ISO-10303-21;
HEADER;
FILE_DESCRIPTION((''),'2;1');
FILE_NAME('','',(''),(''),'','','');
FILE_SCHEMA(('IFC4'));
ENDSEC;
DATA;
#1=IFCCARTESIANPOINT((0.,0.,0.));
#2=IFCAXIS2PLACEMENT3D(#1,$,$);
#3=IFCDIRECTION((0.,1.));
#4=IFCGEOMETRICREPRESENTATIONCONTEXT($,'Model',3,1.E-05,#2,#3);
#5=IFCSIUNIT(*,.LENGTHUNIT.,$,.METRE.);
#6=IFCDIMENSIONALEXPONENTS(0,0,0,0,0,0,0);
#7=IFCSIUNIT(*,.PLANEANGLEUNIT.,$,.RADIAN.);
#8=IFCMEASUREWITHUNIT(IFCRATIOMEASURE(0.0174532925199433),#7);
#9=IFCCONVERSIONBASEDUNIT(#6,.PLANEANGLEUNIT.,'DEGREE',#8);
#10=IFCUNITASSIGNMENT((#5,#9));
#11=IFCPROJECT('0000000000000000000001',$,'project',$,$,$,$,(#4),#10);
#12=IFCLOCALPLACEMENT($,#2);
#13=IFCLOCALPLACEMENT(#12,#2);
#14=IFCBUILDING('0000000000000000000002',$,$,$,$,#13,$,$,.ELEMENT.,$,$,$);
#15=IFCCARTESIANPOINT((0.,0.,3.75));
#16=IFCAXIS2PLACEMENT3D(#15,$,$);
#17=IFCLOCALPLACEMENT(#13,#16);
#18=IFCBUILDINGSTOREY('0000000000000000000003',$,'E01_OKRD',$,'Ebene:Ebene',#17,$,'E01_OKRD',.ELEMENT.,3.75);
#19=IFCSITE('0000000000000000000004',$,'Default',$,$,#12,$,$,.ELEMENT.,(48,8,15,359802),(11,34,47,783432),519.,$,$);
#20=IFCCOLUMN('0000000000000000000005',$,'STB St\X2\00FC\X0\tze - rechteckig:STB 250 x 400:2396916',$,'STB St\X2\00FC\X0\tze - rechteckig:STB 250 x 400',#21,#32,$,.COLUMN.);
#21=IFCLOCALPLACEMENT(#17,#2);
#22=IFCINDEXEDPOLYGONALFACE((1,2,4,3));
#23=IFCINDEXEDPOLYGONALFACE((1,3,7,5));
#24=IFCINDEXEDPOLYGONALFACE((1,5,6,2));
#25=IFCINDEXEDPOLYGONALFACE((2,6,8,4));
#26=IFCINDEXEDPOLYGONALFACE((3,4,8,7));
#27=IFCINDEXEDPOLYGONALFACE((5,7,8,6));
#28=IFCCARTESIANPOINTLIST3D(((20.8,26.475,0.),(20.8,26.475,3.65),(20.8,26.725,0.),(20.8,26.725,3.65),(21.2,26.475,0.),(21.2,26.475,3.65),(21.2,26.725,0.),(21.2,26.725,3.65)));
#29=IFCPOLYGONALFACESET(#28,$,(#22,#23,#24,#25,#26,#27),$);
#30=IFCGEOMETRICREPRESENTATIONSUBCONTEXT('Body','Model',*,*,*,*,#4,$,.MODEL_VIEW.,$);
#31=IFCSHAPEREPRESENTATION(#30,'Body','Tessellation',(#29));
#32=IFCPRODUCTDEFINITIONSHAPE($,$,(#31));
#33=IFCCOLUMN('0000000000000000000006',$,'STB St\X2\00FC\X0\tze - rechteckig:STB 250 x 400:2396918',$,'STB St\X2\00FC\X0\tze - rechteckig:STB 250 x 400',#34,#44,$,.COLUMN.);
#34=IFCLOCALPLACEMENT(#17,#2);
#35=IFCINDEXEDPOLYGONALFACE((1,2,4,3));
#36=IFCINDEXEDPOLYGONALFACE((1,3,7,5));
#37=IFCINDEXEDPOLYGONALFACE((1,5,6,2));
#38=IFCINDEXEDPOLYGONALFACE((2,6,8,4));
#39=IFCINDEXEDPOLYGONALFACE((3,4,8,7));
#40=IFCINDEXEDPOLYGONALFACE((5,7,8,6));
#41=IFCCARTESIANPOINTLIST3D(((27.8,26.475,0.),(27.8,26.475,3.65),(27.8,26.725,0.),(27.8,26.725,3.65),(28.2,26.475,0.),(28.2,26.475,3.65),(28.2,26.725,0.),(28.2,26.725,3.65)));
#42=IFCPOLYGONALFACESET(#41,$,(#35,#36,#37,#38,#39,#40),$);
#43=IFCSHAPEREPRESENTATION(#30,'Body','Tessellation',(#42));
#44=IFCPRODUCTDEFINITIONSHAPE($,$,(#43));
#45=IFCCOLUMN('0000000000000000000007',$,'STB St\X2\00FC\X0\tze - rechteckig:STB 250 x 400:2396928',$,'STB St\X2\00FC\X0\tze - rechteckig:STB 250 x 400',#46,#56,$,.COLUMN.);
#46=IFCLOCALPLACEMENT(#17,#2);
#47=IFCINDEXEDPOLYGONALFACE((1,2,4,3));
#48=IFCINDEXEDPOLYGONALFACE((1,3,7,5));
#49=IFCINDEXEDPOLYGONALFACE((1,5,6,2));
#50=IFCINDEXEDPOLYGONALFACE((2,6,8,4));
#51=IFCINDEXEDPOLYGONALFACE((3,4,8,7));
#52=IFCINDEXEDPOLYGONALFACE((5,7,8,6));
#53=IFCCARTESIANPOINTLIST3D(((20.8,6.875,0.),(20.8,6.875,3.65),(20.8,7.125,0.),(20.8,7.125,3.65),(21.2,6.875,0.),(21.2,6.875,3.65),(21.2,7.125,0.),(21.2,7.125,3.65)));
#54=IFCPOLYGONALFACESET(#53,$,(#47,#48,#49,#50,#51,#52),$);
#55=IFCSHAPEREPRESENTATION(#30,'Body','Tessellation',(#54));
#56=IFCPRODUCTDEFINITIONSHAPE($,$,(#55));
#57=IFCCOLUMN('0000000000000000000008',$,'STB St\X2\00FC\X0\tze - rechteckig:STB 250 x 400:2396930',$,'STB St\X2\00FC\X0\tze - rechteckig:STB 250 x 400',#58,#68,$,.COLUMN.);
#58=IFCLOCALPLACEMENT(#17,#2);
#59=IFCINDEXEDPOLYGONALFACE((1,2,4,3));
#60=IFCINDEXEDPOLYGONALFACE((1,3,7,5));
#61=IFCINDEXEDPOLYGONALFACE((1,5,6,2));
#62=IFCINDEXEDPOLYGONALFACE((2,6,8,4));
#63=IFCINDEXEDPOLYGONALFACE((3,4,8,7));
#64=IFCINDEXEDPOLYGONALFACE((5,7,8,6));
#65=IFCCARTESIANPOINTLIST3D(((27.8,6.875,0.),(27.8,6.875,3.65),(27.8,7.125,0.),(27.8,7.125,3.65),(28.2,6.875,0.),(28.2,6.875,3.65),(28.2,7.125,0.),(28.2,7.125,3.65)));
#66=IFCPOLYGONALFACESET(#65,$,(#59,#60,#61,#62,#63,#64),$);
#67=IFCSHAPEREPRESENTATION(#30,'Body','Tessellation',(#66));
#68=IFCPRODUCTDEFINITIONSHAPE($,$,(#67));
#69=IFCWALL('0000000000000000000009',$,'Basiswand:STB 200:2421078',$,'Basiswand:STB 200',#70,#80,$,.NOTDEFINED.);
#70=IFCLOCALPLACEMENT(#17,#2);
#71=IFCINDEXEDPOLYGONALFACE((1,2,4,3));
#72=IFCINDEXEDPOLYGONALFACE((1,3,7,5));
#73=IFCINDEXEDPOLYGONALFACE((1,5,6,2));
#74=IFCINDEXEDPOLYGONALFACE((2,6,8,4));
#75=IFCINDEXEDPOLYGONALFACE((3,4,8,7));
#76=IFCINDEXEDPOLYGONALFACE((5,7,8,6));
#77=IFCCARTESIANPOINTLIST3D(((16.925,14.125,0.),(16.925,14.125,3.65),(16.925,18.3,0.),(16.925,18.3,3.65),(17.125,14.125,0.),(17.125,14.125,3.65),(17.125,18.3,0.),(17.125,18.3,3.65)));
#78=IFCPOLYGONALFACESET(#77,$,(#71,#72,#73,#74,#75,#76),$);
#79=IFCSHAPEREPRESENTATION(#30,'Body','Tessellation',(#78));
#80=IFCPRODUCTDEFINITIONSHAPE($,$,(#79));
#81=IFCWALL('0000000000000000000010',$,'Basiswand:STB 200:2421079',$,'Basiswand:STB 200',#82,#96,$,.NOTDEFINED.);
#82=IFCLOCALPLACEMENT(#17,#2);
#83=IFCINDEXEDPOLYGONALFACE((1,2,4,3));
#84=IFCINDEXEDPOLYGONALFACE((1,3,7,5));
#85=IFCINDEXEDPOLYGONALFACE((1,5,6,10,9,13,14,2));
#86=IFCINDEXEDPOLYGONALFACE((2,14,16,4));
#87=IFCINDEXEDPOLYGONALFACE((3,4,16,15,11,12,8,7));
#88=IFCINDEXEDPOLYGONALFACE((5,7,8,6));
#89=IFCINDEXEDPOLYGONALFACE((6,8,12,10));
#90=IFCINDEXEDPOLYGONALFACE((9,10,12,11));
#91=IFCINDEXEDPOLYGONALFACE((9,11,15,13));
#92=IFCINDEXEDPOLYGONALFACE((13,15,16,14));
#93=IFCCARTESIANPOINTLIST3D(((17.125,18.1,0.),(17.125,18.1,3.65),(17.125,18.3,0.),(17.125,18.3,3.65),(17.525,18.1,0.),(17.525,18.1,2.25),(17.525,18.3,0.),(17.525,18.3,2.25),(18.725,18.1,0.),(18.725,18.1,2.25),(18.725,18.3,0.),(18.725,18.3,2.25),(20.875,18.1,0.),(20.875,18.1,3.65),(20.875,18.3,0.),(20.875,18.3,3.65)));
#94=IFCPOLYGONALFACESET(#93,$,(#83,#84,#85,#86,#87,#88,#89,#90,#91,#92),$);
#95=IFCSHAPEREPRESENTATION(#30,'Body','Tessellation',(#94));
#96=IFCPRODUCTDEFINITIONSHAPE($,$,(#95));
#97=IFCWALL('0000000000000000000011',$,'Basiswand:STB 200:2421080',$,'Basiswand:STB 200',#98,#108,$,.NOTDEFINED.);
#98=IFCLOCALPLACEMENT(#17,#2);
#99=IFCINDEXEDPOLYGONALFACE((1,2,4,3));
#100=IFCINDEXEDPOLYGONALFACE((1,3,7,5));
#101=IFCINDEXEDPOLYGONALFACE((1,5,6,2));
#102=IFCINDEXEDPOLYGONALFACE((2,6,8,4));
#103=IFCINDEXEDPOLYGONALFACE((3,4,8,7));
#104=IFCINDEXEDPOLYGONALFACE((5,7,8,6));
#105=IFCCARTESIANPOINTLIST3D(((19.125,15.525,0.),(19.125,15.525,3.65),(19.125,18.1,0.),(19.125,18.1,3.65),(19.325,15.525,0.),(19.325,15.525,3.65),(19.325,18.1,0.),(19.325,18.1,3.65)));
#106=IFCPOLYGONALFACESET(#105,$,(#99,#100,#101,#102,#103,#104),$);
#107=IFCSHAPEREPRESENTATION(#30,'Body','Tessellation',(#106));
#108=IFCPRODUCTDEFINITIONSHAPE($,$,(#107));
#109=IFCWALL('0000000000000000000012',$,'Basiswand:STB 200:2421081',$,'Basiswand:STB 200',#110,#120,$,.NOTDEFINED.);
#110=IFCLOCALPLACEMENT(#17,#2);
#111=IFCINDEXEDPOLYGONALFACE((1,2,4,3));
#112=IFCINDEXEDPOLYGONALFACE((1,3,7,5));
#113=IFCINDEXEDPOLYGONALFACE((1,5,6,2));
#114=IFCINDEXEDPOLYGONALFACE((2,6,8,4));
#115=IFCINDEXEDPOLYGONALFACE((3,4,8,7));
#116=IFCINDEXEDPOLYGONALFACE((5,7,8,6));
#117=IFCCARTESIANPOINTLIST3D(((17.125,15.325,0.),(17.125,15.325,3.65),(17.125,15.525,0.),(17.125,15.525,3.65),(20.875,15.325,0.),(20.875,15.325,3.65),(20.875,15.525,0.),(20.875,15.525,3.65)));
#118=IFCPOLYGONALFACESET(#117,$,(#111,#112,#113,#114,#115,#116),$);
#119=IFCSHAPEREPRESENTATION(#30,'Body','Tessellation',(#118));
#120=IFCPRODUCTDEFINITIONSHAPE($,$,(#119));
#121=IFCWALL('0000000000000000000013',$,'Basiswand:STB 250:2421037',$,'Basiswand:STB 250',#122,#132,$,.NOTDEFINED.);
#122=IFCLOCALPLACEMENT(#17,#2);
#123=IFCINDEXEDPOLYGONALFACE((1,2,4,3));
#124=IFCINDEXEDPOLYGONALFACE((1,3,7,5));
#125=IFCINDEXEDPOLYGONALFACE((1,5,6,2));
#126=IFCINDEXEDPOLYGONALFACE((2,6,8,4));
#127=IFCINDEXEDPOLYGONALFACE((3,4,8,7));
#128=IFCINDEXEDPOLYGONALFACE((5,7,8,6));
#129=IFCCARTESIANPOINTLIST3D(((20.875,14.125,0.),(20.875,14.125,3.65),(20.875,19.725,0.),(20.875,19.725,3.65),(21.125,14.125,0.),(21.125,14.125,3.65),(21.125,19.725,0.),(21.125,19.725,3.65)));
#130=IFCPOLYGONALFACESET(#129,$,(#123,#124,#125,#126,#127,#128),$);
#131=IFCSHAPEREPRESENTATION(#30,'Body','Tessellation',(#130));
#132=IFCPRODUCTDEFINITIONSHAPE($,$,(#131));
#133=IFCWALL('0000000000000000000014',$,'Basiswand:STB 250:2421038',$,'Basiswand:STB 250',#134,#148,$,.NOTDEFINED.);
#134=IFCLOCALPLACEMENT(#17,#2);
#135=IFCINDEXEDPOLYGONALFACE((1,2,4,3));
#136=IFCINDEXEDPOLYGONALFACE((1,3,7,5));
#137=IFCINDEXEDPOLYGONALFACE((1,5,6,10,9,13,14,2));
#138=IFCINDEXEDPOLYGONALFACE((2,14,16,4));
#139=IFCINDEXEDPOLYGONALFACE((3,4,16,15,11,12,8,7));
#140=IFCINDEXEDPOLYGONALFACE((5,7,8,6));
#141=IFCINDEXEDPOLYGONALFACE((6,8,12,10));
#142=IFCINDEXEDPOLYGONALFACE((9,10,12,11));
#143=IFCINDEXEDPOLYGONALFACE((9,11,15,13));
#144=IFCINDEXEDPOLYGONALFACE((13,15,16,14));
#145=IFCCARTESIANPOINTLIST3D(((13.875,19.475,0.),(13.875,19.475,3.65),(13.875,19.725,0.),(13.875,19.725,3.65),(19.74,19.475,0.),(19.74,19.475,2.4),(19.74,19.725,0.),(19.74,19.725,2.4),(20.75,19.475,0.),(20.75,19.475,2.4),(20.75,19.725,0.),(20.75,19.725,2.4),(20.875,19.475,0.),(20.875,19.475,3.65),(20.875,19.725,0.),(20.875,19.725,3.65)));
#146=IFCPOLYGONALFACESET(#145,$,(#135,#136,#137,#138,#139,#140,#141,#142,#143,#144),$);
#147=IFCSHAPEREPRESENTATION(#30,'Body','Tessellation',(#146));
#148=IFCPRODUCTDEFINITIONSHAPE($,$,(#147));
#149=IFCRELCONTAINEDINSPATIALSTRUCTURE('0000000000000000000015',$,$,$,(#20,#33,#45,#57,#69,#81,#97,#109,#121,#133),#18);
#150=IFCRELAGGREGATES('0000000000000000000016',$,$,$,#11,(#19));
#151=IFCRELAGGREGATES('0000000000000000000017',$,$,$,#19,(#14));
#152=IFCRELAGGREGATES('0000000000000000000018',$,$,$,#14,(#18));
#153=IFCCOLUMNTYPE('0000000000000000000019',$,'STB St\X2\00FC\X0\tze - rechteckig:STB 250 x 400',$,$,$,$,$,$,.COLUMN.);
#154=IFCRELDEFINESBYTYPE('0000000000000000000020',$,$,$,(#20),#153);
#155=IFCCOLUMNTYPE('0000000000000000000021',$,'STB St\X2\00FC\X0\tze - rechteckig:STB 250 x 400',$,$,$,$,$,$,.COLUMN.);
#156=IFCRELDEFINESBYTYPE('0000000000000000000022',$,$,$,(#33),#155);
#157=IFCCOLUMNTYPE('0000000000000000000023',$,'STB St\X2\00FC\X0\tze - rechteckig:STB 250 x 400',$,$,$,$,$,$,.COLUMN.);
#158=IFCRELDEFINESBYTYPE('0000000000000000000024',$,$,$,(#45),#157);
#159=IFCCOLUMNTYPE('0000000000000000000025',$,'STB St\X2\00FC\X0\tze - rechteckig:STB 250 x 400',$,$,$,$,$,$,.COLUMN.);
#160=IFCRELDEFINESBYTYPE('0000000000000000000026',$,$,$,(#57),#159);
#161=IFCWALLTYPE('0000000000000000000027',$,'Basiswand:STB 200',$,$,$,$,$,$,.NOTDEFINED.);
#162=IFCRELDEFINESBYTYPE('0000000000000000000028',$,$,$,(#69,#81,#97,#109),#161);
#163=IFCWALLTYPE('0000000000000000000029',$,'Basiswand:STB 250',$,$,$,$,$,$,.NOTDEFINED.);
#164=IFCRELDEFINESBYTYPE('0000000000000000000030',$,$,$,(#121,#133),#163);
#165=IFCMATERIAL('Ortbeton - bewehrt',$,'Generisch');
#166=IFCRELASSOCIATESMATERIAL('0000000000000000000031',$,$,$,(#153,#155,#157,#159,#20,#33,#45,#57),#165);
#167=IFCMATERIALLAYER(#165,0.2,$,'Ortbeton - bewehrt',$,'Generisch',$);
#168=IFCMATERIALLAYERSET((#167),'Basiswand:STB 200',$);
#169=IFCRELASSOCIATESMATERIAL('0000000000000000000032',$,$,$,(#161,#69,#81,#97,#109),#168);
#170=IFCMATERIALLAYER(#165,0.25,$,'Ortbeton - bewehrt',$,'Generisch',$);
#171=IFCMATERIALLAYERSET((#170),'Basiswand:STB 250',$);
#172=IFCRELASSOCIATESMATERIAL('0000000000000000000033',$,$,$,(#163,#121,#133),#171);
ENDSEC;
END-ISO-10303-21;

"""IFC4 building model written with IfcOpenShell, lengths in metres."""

from ifc_helpers import new_model, entity, si_unit, converted_unit, direction, frame, frame_2d, origin, place, context, subcontext, project, spatial, rectangle, extrude, source, transform, mapped, material, layer, layer_set, layer_usage, material_profile, profile_set, profile_usage, type_object, type_shapes, element, save


model = new_model("IFC4")

# Units and contexts
model_context = context("Model", 3, precision=1e-05, world=origin(), true_north=direction((0.0, 1.0)))
body_context = subcontext(model_context, "Body", "Model", "MODEL_VIEW")
ifc_project = project(units=[si_unit("LENGTHUNIT", "METRE"), converted_unit("PLANEANGLEUNIT", "DEGREE", entity("IfcRatioMeasure", 0.0174532925199433), si_unit("PLANEANGLEUNIT", "RADIAN"), dimensions=[0, 0, 0, 0, 0, 0, 0])], contexts=[model_context])

# Site, building, storey
site_placement = place(None, frame((0.0, 0.0, 0.0)))
site = spatial("IfcSite", under=ifc_project, at=site_placement, Name="Default", CompositionType="ELEMENT", RefLatitude=(48, 8, 15, 359802), RefLongitude=(11, 34, 47, 783432), RefElevation=519.0)
building_placement = place(site_placement, origin())
building = spatial("IfcBuilding", under=site, at=building_placement, CompositionType="ELEMENT")
storey_placement = place(building_placement, frame((0.0, 0.0, 3.75)))
storey = spatial("IfcBuildingStorey", under=building, at=storey_placement, Name="E01_OKRD", ObjectType="Ebene:Ebene", LongName="E01_OKRD", CompositionType="ELEMENT", Elevation=3.75)

# Columns
ifc_material_1 = material(Name="Ortbeton - bewehrt", Category="Generisch")
ifc_material_profile = material_profile(ifc_material_1, rectangle(XDim=0.4, YDim=0.25, at=frame_2d((0.0, 0.0), x_axis=(1.0, 0.0))), Name="STB 250 x 400")
ifc_profile_set = profile_set([ifc_material_profile], Name="STB 250 x 400")
ifc_profile_usage_1 = profile_usage(ifc_profile_set)
column_type_1 = type_object("IfcColumnType", Name="STB Stütze - rechteckig:STB 250 x 400", PredefinedType="COLUMN", material=ifc_profile_set)
shared_shape_1 = source(origin(), body_context, "Body", "SweptSolid", [
    extrude(rectangle(XDim=0.4, YDim=0.25, at=frame_2d((0.0, 0.0), x_axis=(1.0, 0.0))), frame((0.2, 0.125, 0.0), z_axis=(0.0, 0.0, 1.0), x_axis=(-1.0, 0.0, 0.0)), (0.0, 0.0, 1.0), 3.65),
])
type_shapes(column_type_1, [shared_shape_1])
column_1_placement = place(storey_placement, frame((20.8, 26.475, 0.0)))
element("IfcColumn", 1, at=column_1_placement, inside=storey, type_object=column_type_1, material=ifc_profile_usage_1, Name="STB Stütze - rechteckig:STB 250 x 400:2396916", ObjectType="STB Stütze - rechteckig:STB 250 x 400", PredefinedType="COLUMN", context=body_context, shape_type="MappedRepresentation", body=[
    mapped(shared_shape_1, transform((0.0, 0.0, 0.0), scale=1.0)),
])
ifc_profile_usage_2 = profile_usage(ifc_profile_set)
column_type_2 = type_object("IfcColumnType", Name="STB Stütze - rechteckig:STB 250 x 400", PredefinedType="COLUMN", material=ifc_profile_set)
shared_shape_2 = source(origin(), body_context, "Body", "SweptSolid", [
    extrude(rectangle(XDim=0.4, YDim=0.25, at=frame_2d((0.0, 0.0), x_axis=(1.0, 0.0))), frame((0.2, 0.125, 0.0), z_axis=(0.0, 0.0, 1.0), x_axis=(-1.0, 0.0, 0.0)), (0.0, 0.0, 1.0), 3.65),
])
type_shapes(column_type_2, [shared_shape_2])
column_2_placement = place(storey_placement, frame((27.8, 26.475, 0.0)))
element("IfcColumn", 2, at=column_2_placement, inside=storey, type_object=column_type_2, material=ifc_profile_usage_2, Name="STB Stütze - rechteckig:STB 250 x 400:2396918", ObjectType="STB Stütze - rechteckig:STB 250 x 400", PredefinedType="COLUMN", context=body_context, shape_type="MappedRepresentation", body=[
    mapped(shared_shape_2, transform((0.0, 0.0, 0.0), scale=1.0)),
])
ifc_profile_usage_3 = profile_usage(ifc_profile_set)
column_type_3 = type_object("IfcColumnType", Name="STB Stütze - rechteckig:STB 250 x 400", PredefinedType="COLUMN", material=ifc_profile_set)
shared_shape_3 = source(origin(), body_context, "Body", "SweptSolid", [
    extrude(rectangle(XDim=0.4, YDim=0.25, at=frame_2d((0.0, 0.0), x_axis=(1.0, 0.0))), frame((0.2, 0.125, 0.0), z_axis=(0.0, 0.0, 1.0), x_axis=(-1.0, 0.0, 0.0)), (0.0, 0.0, 1.0), 3.65),
])
type_shapes(column_type_3, [shared_shape_3])
column_3_placement = place(storey_placement, frame((20.8, 6.875, 0.0)))
element("IfcColumn", 3, at=column_3_placement, inside=storey, type_object=column_type_3, material=ifc_profile_usage_3, Name="STB Stütze - rechteckig:STB 250 x 400:2396928", ObjectType="STB Stütze - rechteckig:STB 250 x 400", PredefinedType="COLUMN", context=body_context, shape_type="MappedRepresentation", body=[
    mapped(shared_shape_3, transform((0.0, 0.0, 0.0), scale=1.0)),
])
ifc_profile_usage_4 = profile_usage(ifc_profile_set)
column_type_4 = type_object("IfcColumnType", Name="STB Stütze - rechteckig:STB 250 x 400", PredefinedType="COLUMN", material=ifc_profile_set)
shared_shape_4 = source(origin(), body_context, "Body", "SweptSolid", [
    extrude(rectangle(XDim=0.4, YDim=0.25, at=frame_2d((0.0, 0.0), x_axis=(1.0, 0.0))), frame((0.2, 0.125, 0.0), z_axis=(0.0, 0.0, 1.0), x_axis=(-1.0, 0.0, 0.0)), (0.0, 0.0, 1.0), 3.65),
])
type_shapes(column_type_4, [shared_shape_4])
column_4_placement = place(storey_placement, frame((27.8, 6.875, 0.0)))
element("IfcColumn", 4, at=column_4_placement, inside=storey, type_object=column_type_4, material=ifc_profile_usage_4, Name="STB Stütze - rechteckig:STB 250 x 400:2396930", ObjectType="STB Stütze - rechteckig:STB 250 x 400", PredefinedType="COLUMN", context=body_context, shape_type="MappedRepresentation", body=[
    mapped(shared_shape_4, transform((0.0, 0.0, 0.0), scale=1.0)),
])

# Wall
ifc_layer_1 = layer(ifc_material_1, 0.2, Name="Ortbeton - bewehrt", Category="Generisch")
ifc_layer_set_1 = layer_set([ifc_layer_1], Name="Basiswand:STB 200")
ifc_layer_usage_1 = layer_usage(ifc_layer_set_1, "AXIS2", "NEGATIVE", 0.1)
wall_type_1 = type_object("IfcWallType", Name="Basiswand:STB 200", PredefinedType="NOTDEFINED", material=ifc_layer_set_1)
wall_1_placement = place(storey_placement, frame((17.025, 14.125, 0.0), z_axis=(0.0, 0.0, 1.0), x_axis=(0.0, 1.0, 0.0)))
element("IfcWall", 5, at=wall_1_placement, inside=storey, type_object=wall_type_1, material=ifc_layer_usage_1, Name="Basiswand:STB 200:2421078", ObjectType="Basiswand:STB 200", PredefinedType="NOTDEFINED", context=body_context, shape_type="SweptSolid", body=[
    extrude(rectangle(XDim=4.175, YDim=0.2, at=frame_2d((2.0875, 0.0), x_axis=(-1.0, 0.0))), origin(), (0.0, 0.0, 1.0), 3.65),
])

# Wall, opening
ifc_layer_usage_2 = layer_usage(ifc_layer_set_1, "AXIS2", "NEGATIVE", 0.1)
wall_2_placement = place(storey_placement, frame((17.125, 18.2, 0.0)))
wall_2 = element("IfcWall", 6, at=wall_2_placement, inside=storey, type_object=wall_type_1, material=ifc_layer_usage_2, Name="Basiswand:STB 200:2421079", ObjectType="Basiswand:STB 200", PredefinedType="NOTDEFINED", context=body_context, shape_type="SweptSolid", body=[
    extrude(rectangle(XDim=3.75, YDim=0.2, at=frame_2d((1.875, 0.0), x_axis=(-1.0, 0.0))), origin(), (0.0, 0.0, 1.0), 3.65),
])
opening_1_placement = place(wall_2_placement, frame((0.4, -0.1, -0.03)))
element("IfcOpeningElement", 7, at=opening_1_placement, cuts=wall_2, ObjectType="Opening", PredefinedType="OPENING", context=body_context, shape_type="SweptSolid", body=[
    extrude(rectangle(XDim=2.28, YDim=1.2, at=frame_2d((1.14, 0.6), x_axis=(1.0, 0.0))), frame((0.0, 0.0, 0.0), z_axis=(0.0, 1.0, 0.0), x_axis=(0.0, 0.0, 1.0)), (0.0, 0.0, 1.0), 0.2),
])

# Walls
ifc_layer_usage_3 = layer_usage(ifc_layer_set_1, "AXIS2", "NEGATIVE", 0.1)
wall_3_placement = place(storey_placement, frame((19.225, 18.1, 0.0), z_axis=(0.0, 0.0, 1.0), x_axis=(0.0, -1.0, 0.0)))
element("IfcWall", 8, at=wall_3_placement, inside=storey, type_object=wall_type_1, material=ifc_layer_usage_3, Name="Basiswand:STB 200:2421080", ObjectType="Basiswand:STB 200", PredefinedType="NOTDEFINED", context=body_context, shape_type="SweptSolid", body=[
    extrude(rectangle(XDim=2.575, YDim=0.2, at=frame_2d((1.2875, 0.0), x_axis=(-1.0, 0.0))), origin(), (0.0, 0.0, 1.0), 3.65),
])
ifc_layer_usage_4 = layer_usage(ifc_layer_set_1, "AXIS2", "NEGATIVE", 0.1)
wall_4_placement = place(storey_placement, frame((20.875, 15.425, 0.0), z_axis=(0.0, 0.0, 1.0), x_axis=(-1.0, 0.0, 0.0)))
element("IfcWall", 9, at=wall_4_placement, inside=storey, type_object=wall_type_1, material=ifc_layer_usage_4, Name="Basiswand:STB 200:2421081", ObjectType="Basiswand:STB 200", PredefinedType="NOTDEFINED", context=body_context, shape_type="SweptSolid", body=[
    extrude(rectangle(XDim=3.75, YDim=0.2, at=frame_2d((1.875, 0.0), x_axis=(-1.0, 0.0))), origin(), (0.0, 0.0, 1.0), 3.65),
])
ifc_layer_2 = layer(ifc_material_1, 0.25, Name="Ortbeton - bewehrt", Category="Generisch")
ifc_layer_set_2 = layer_set([ifc_layer_2], Name="Basiswand:STB 250")
ifc_layer_usage_5 = layer_usage(ifc_layer_set_2, "AXIS2", "POSITIVE", -0.125)
wall_type_2 = type_object("IfcWallType", Name="Basiswand:STB 250", PredefinedType="NOTDEFINED", material=ifc_layer_set_2)
wall_5_placement = place(storey_placement, frame((21.0, 14.125, 0.0), z_axis=(0.0, 0.0, 1.0), x_axis=(0.0, 1.0, 0.0)))
element("IfcWall", 10, at=wall_5_placement, inside=storey, type_object=wall_type_2, material=ifc_layer_usage_5, Name="Basiswand:STB 250:2421037", ObjectType="Basiswand:STB 250", PredefinedType="NOTDEFINED", context=body_context, shape_type="SweptSolid", body=[
    extrude(rectangle(XDim=5.6, YDim=0.25, at=frame_2d((2.8, 0.0), x_axis=(-1.0, 0.0))), origin(), (0.0, 0.0, 1.0), 3.65),
])

# Wall, opening
ifc_layer_usage_6 = layer_usage(ifc_layer_set_2, "AXIS2", "POSITIVE", -0.125)
wall_6_placement = place(storey_placement, frame((20.875, 19.6, 0.0), z_axis=(0.0, 0.0, 1.0), x_axis=(-1.0, 0.0, 0.0)))
wall_6 = element("IfcWall", 11, at=wall_6_placement, inside=storey, type_object=wall_type_2, material=ifc_layer_usage_6, Name="Basiswand:STB 250:2421038", ObjectType="Basiswand:STB 250", PredefinedType="NOTDEFINED", context=body_context, shape_type="SweptSolid", body=[
    extrude(rectangle(XDim=7.0, YDim=0.25, at=frame_2d((3.5, 0.0), x_axis=(-1.0, 0.0))), origin(), (0.0, 0.0, 1.0), 3.65),
])
opening_2_placement = place(wall_6_placement, frame((1.135, 0.125, 0.0), z_axis=(0.0, 0.0, 1.0), x_axis=(-1.0, 0.0, 0.0)))
element("IfcOpeningElement", 12, at=opening_2_placement, cuts=wall_6, ObjectType="Opening", PredefinedType="OPENING", context=body_context, shape_type="SweptSolid", body=[
    extrude(rectangle(XDim=2.4, YDim=1.01, at=frame_2d((0.0, 0.0), x_axis=(1.0, 0.0))), frame((0.505, 0.25, 1.2), z_axis=(0.0, -1.0, 0.0), x_axis=(0.0, 0.0, -1.0)), (0.0, 0.0, 1.0), 0.25),
    extrude(rectangle(XDim=2.27, YDim=0.95, at=frame_2d((0.0, 0.0), x_axis=(1.0, 0.0))), frame((0.505, 0.55, 1.235), z_axis=(0.0, -1.0, 0.0), x_axis=(0.0, 0.0, -1.0)), (0.0, 0.0, 1.0), 0.255),
])

save(model, "model.ifc")
